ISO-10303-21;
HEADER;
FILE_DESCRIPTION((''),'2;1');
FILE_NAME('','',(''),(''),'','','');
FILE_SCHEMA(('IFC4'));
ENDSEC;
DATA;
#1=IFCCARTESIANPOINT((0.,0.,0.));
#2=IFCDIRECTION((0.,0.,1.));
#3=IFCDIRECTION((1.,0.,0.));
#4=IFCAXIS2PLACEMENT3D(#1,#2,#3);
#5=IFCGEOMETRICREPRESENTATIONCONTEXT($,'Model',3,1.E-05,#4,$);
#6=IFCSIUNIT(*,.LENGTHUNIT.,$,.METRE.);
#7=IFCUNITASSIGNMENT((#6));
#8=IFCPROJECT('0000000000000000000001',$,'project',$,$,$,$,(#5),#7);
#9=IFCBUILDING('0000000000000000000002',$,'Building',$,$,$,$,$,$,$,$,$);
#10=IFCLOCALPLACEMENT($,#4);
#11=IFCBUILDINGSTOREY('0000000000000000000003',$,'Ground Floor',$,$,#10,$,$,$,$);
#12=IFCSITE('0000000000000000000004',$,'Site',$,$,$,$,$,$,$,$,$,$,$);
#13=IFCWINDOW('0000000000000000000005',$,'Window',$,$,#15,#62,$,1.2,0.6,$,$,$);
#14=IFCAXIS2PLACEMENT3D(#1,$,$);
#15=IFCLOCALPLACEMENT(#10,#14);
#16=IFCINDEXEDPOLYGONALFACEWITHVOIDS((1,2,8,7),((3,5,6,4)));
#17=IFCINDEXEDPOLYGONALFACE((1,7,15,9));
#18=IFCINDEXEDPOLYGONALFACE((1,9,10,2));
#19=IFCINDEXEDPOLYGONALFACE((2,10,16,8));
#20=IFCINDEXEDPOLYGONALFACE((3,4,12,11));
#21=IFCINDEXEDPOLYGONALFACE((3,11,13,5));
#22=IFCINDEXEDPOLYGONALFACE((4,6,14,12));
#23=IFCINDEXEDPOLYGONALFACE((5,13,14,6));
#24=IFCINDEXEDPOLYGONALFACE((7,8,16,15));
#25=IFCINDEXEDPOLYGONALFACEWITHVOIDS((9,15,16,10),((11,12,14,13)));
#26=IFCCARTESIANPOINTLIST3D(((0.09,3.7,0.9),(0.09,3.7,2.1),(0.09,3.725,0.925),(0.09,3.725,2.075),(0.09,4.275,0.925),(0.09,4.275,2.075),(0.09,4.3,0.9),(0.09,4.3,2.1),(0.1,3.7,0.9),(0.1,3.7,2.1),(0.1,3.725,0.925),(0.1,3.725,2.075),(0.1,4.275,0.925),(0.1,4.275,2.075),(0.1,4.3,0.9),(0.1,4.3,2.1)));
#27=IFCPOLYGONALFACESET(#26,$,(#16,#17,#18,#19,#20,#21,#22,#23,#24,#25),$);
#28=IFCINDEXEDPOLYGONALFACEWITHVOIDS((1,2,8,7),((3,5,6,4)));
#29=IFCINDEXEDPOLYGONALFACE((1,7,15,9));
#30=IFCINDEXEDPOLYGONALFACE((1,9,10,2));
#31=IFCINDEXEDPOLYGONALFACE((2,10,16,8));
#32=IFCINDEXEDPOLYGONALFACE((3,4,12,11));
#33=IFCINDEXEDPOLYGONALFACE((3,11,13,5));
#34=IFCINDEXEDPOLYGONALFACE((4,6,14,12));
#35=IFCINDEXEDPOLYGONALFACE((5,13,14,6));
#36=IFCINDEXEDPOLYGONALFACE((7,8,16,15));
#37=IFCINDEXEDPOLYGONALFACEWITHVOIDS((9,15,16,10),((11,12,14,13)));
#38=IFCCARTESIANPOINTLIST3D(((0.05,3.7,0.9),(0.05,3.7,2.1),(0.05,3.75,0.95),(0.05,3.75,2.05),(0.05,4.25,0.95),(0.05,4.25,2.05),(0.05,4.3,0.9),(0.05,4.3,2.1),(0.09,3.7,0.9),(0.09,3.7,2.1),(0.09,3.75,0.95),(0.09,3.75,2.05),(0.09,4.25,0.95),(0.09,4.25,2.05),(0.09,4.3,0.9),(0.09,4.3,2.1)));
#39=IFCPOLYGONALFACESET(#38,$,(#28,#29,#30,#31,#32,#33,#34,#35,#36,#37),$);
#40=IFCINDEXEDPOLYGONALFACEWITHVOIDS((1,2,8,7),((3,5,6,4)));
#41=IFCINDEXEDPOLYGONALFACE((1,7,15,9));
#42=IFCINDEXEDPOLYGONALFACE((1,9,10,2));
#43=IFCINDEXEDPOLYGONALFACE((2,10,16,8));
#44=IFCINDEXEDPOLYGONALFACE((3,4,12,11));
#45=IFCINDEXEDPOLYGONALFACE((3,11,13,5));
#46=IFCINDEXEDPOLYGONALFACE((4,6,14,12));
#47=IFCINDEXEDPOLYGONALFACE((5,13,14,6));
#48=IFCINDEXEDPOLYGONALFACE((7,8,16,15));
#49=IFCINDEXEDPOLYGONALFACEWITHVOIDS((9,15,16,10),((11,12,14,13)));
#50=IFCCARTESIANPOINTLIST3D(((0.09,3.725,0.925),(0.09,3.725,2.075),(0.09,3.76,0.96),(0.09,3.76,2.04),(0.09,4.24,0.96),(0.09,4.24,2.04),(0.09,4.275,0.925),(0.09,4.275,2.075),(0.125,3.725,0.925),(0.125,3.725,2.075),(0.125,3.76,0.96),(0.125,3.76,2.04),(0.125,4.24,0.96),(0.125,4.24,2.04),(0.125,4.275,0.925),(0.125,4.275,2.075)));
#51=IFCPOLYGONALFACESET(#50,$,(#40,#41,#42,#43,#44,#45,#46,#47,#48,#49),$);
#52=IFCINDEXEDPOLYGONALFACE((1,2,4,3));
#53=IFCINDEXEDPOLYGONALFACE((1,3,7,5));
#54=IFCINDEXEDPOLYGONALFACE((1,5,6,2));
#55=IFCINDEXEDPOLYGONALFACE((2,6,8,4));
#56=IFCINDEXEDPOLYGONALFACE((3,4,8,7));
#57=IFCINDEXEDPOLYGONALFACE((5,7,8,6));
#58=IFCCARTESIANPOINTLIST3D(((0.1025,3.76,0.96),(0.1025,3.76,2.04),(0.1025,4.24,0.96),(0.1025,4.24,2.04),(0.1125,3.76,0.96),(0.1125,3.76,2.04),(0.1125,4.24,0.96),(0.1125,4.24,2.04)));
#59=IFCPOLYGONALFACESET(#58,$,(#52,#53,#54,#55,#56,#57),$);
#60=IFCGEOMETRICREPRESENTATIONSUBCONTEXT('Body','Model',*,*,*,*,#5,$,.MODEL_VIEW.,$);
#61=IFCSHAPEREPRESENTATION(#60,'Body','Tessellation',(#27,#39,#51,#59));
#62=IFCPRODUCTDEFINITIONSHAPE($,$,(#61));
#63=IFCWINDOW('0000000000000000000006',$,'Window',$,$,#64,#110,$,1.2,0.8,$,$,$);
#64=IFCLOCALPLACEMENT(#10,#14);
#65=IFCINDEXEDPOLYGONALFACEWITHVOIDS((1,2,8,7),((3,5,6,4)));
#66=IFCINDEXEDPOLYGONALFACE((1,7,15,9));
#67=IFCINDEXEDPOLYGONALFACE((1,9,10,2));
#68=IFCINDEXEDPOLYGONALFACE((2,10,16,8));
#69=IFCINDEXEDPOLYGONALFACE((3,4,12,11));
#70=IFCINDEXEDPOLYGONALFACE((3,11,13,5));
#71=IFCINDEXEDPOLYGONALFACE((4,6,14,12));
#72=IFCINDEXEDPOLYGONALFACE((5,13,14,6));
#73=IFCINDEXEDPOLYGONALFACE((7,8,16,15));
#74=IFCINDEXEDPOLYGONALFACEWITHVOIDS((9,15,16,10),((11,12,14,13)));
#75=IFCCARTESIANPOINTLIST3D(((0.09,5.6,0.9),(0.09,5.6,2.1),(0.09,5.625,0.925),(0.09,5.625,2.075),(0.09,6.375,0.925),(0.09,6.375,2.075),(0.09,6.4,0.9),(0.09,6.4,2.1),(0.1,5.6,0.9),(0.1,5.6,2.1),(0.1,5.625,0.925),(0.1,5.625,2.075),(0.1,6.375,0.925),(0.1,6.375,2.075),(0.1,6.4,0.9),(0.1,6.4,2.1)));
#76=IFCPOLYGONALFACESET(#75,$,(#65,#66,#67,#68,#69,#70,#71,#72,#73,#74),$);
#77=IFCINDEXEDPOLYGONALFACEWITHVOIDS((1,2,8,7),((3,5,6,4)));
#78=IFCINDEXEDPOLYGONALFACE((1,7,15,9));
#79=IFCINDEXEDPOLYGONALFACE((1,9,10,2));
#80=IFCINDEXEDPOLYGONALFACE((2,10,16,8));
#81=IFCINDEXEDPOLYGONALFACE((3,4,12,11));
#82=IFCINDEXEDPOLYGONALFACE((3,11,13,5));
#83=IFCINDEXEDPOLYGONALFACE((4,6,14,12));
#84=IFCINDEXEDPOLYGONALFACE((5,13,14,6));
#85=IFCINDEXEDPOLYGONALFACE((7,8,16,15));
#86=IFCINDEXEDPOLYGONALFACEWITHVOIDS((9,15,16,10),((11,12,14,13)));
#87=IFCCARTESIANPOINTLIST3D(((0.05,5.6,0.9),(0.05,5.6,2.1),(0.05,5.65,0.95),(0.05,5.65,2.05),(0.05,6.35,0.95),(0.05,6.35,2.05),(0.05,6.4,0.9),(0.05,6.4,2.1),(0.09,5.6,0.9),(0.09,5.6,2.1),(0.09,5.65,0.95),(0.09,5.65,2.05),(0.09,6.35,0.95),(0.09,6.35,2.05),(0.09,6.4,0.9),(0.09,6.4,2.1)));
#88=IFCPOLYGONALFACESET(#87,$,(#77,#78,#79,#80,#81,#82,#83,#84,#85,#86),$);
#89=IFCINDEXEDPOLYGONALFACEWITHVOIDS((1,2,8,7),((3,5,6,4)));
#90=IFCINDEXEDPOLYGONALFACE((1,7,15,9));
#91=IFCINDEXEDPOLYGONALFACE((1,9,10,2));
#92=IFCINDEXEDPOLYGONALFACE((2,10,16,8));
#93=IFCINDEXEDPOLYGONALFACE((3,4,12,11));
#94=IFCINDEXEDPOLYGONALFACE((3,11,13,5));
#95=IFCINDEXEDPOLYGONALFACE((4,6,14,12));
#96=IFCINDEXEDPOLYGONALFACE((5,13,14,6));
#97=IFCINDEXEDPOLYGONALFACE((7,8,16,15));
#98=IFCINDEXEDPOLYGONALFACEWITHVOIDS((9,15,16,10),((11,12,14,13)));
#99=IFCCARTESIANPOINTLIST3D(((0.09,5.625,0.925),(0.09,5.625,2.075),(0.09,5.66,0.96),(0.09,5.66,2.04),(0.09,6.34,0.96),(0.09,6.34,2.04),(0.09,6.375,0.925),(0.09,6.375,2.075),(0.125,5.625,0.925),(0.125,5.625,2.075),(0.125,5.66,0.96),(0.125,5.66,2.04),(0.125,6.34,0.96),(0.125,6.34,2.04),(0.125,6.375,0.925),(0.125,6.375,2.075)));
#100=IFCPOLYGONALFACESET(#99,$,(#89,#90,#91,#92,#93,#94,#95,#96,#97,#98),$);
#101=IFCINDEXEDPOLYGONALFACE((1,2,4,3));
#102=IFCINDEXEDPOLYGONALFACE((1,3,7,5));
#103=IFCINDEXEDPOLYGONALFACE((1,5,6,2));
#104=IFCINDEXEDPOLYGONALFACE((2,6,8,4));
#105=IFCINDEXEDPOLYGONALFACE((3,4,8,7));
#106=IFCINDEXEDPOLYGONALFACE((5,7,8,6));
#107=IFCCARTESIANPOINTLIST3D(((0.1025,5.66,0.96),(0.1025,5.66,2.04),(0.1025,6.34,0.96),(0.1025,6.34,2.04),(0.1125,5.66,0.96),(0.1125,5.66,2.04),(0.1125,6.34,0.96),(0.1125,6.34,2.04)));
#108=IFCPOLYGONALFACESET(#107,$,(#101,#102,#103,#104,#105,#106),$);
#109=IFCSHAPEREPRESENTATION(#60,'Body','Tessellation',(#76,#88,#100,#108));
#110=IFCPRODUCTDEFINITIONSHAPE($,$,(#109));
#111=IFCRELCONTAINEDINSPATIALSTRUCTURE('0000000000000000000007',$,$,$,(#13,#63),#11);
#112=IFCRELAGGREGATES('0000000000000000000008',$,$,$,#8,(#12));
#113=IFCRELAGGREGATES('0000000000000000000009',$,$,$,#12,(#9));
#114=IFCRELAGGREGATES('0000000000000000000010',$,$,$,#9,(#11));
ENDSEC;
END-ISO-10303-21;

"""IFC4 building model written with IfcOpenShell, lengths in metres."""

from ifc_helpers import new_model, si_unit, frame, origin_with_axes, place, context, subcontext, project, spatial, line, indexed_curve, outline, extrude, element, save


model = new_model("IFC4")

# Units and contexts
model_context = context("Model", 3, precision=1e-05, world=origin_with_axes())
body_context = subcontext(model_context, "Body", "Model", "MODEL_VIEW")
ifc_project = project(units=[si_unit("LENGTHUNIT", "METRE")], contexts=[model_context])

# Site, building, storey
site = spatial("IfcSite", under=ifc_project, Name="Site")
building = spatial("IfcBuilding", under=site, Name="Building")
storey_placement = place(None, origin_with_axes())
storey = spatial("IfcBuildingStorey", under=building, at=storey_placement, Name="Ground Floor")

# Windows
window_1_placement = place(storey_placement, frame((0.0, 4.3, 0.9), z_axis=(0.0, 0.0, 1.0), x_axis=(0.0, -1.0, 0.0)))
element("IfcWindow", 1, at=window_1_placement, inside=storey, Name="Window", OverallHeight=1.2, OverallWidth=0.6, context=body_context, shape_type="SweptSolid", body=[
    extrude(outline(indexed_curve([(0.0, 0.0), (0.6, 0.0), (0.6, 1.2), (0.0, 1.2)], segments=[line(1, 2, 3, 4, 1)]), holes=[indexed_curve([(0.025, 0.025), (0.575, 0.025), (0.575, 1.175), (0.025, 1.175)], segments=[line(1, 2, 3, 4, 1)])]), frame((0.0, 0.09, 0.0), z_axis=(0.0, -1.0, 0.0), x_axis=(1.0, 0.0, 0.0)), (0.0, 0.0, -1.0), 0.01),
    extrude(outline(indexed_curve([(0.0, 0.0), (0.6, 0.0), (0.6, 1.2), (0.0, 1.2)], segments=[line(1, 2, 3, 4, 1)]), holes=[indexed_curve([(0.05, 0.05), (0.55, 0.05), (0.55, 1.15), (0.05, 1.15)], segments=[line(1, 2, 3, 4, 1)])]), frame((0.0, 0.05, 0.0), z_axis=(0.0, -1.0, 0.0), x_axis=(1.0, 0.0, 0.0)), (0.0, 0.0, -1.0), 0.04),
    extrude(outline(indexed_curve([(0.0, 0.0), (0.55, 0.0), (0.55, 1.15), (0.0, 1.15)], segments=[line(1, 2, 3, 4, 1)]), holes=[indexed_curve([(0.035, 0.035), (0.515, 0.035), (0.515, 1.115), (0.035, 1.115)], segments=[line(1, 2, 3, 4, 1)])]), frame((0.025, 0.09, 0.025), z_axis=(0.0, -1.0, 0.0), x_axis=(1.0, 0.0, 0.0)), (0.0, 0.0, -1.0), 0.035),
    extrude(outline(indexed_curve([(0.035, 0.035), (0.515, 0.035), (0.515, 1.115), (0.035, 1.115)], segments=[line(1, 2, 3, 4, 1)])), frame((0.025, 0.1025, 0.025), z_axis=(0.0, -1.0, 0.0), x_axis=(1.0, 0.0, 0.0)), (0.0, 0.0, -1.0), 0.01),
])
window_2_placement = place(storey_placement, frame((0.0, 6.4, 0.9), z_axis=(0.0, 0.0, 1.0), x_axis=(0.0, -1.0, 0.0)))
element("IfcWindow", 2, at=window_2_placement, inside=storey, Name="Window", OverallHeight=1.2, OverallWidth=0.8, context=body_context, shape_type="SweptSolid", body=[
    extrude(outline(indexed_curve([(0.0, 0.0), (0.8, 0.0), (0.8, 1.2), (0.0, 1.2)], segments=[line(1, 2, 3, 4, 1)]), holes=[indexed_curve([(0.025, 0.025), (0.775, 0.025), (0.775, 1.175), (0.025, 1.175)], segments=[line(1, 2, 3, 4, 1)])]), frame((0.0, 0.09, 0.0), z_axis=(0.0, -1.0, 0.0), x_axis=(1.0, 0.0, 0.0)), (0.0, 0.0, -1.0), 0.01),
    extrude(outline(indexed_curve([(0.0, 0.0), (0.8, 0.0), (0.8, 1.2), (0.0, 1.2)], segments=[line(1, 2, 3, 4, 1)]), holes=[indexed_curve([(0.05, 0.05), (0.75, 0.05), (0.75, 1.15), (0.05, 1.15)], segments=[line(1, 2, 3, 4, 1)])]), frame((0.0, 0.05, 0.0), z_axis=(0.0, -1.0, 0.0), x_axis=(1.0, 0.0, 0.0)), (0.0, 0.0, -1.0), 0.04),
    extrude(outline(indexed_curve([(0.0, 0.0), (0.75, 0.0), (0.75, 1.15), (0.0, 1.15)], segments=[line(1, 2, 3, 4, 1)]), holes=[indexed_curve([(0.035, 0.035), (0.715, 0.035), (0.715, 1.115), (0.035, 1.115)], segments=[line(1, 2, 3, 4, 1)])]), frame((0.025, 0.09, 0.025), z_axis=(0.0, -1.0, 0.0), x_axis=(1.0, 0.0, 0.0)), (0.0, 0.0, -1.0), 0.035),
    extrude(outline(indexed_curve([(0.035, 0.035), (0.715, 0.035), (0.715, 1.115), (0.035, 1.115)], segments=[line(1, 2, 3, 4, 1)])), frame((0.025, 0.1025, 0.025), z_axis=(0.0, -1.0, 0.0), x_axis=(1.0, 0.0, 0.0)), (0.0, 0.0, -1.0), 0.01),
])

save(model, "model.ifc")
